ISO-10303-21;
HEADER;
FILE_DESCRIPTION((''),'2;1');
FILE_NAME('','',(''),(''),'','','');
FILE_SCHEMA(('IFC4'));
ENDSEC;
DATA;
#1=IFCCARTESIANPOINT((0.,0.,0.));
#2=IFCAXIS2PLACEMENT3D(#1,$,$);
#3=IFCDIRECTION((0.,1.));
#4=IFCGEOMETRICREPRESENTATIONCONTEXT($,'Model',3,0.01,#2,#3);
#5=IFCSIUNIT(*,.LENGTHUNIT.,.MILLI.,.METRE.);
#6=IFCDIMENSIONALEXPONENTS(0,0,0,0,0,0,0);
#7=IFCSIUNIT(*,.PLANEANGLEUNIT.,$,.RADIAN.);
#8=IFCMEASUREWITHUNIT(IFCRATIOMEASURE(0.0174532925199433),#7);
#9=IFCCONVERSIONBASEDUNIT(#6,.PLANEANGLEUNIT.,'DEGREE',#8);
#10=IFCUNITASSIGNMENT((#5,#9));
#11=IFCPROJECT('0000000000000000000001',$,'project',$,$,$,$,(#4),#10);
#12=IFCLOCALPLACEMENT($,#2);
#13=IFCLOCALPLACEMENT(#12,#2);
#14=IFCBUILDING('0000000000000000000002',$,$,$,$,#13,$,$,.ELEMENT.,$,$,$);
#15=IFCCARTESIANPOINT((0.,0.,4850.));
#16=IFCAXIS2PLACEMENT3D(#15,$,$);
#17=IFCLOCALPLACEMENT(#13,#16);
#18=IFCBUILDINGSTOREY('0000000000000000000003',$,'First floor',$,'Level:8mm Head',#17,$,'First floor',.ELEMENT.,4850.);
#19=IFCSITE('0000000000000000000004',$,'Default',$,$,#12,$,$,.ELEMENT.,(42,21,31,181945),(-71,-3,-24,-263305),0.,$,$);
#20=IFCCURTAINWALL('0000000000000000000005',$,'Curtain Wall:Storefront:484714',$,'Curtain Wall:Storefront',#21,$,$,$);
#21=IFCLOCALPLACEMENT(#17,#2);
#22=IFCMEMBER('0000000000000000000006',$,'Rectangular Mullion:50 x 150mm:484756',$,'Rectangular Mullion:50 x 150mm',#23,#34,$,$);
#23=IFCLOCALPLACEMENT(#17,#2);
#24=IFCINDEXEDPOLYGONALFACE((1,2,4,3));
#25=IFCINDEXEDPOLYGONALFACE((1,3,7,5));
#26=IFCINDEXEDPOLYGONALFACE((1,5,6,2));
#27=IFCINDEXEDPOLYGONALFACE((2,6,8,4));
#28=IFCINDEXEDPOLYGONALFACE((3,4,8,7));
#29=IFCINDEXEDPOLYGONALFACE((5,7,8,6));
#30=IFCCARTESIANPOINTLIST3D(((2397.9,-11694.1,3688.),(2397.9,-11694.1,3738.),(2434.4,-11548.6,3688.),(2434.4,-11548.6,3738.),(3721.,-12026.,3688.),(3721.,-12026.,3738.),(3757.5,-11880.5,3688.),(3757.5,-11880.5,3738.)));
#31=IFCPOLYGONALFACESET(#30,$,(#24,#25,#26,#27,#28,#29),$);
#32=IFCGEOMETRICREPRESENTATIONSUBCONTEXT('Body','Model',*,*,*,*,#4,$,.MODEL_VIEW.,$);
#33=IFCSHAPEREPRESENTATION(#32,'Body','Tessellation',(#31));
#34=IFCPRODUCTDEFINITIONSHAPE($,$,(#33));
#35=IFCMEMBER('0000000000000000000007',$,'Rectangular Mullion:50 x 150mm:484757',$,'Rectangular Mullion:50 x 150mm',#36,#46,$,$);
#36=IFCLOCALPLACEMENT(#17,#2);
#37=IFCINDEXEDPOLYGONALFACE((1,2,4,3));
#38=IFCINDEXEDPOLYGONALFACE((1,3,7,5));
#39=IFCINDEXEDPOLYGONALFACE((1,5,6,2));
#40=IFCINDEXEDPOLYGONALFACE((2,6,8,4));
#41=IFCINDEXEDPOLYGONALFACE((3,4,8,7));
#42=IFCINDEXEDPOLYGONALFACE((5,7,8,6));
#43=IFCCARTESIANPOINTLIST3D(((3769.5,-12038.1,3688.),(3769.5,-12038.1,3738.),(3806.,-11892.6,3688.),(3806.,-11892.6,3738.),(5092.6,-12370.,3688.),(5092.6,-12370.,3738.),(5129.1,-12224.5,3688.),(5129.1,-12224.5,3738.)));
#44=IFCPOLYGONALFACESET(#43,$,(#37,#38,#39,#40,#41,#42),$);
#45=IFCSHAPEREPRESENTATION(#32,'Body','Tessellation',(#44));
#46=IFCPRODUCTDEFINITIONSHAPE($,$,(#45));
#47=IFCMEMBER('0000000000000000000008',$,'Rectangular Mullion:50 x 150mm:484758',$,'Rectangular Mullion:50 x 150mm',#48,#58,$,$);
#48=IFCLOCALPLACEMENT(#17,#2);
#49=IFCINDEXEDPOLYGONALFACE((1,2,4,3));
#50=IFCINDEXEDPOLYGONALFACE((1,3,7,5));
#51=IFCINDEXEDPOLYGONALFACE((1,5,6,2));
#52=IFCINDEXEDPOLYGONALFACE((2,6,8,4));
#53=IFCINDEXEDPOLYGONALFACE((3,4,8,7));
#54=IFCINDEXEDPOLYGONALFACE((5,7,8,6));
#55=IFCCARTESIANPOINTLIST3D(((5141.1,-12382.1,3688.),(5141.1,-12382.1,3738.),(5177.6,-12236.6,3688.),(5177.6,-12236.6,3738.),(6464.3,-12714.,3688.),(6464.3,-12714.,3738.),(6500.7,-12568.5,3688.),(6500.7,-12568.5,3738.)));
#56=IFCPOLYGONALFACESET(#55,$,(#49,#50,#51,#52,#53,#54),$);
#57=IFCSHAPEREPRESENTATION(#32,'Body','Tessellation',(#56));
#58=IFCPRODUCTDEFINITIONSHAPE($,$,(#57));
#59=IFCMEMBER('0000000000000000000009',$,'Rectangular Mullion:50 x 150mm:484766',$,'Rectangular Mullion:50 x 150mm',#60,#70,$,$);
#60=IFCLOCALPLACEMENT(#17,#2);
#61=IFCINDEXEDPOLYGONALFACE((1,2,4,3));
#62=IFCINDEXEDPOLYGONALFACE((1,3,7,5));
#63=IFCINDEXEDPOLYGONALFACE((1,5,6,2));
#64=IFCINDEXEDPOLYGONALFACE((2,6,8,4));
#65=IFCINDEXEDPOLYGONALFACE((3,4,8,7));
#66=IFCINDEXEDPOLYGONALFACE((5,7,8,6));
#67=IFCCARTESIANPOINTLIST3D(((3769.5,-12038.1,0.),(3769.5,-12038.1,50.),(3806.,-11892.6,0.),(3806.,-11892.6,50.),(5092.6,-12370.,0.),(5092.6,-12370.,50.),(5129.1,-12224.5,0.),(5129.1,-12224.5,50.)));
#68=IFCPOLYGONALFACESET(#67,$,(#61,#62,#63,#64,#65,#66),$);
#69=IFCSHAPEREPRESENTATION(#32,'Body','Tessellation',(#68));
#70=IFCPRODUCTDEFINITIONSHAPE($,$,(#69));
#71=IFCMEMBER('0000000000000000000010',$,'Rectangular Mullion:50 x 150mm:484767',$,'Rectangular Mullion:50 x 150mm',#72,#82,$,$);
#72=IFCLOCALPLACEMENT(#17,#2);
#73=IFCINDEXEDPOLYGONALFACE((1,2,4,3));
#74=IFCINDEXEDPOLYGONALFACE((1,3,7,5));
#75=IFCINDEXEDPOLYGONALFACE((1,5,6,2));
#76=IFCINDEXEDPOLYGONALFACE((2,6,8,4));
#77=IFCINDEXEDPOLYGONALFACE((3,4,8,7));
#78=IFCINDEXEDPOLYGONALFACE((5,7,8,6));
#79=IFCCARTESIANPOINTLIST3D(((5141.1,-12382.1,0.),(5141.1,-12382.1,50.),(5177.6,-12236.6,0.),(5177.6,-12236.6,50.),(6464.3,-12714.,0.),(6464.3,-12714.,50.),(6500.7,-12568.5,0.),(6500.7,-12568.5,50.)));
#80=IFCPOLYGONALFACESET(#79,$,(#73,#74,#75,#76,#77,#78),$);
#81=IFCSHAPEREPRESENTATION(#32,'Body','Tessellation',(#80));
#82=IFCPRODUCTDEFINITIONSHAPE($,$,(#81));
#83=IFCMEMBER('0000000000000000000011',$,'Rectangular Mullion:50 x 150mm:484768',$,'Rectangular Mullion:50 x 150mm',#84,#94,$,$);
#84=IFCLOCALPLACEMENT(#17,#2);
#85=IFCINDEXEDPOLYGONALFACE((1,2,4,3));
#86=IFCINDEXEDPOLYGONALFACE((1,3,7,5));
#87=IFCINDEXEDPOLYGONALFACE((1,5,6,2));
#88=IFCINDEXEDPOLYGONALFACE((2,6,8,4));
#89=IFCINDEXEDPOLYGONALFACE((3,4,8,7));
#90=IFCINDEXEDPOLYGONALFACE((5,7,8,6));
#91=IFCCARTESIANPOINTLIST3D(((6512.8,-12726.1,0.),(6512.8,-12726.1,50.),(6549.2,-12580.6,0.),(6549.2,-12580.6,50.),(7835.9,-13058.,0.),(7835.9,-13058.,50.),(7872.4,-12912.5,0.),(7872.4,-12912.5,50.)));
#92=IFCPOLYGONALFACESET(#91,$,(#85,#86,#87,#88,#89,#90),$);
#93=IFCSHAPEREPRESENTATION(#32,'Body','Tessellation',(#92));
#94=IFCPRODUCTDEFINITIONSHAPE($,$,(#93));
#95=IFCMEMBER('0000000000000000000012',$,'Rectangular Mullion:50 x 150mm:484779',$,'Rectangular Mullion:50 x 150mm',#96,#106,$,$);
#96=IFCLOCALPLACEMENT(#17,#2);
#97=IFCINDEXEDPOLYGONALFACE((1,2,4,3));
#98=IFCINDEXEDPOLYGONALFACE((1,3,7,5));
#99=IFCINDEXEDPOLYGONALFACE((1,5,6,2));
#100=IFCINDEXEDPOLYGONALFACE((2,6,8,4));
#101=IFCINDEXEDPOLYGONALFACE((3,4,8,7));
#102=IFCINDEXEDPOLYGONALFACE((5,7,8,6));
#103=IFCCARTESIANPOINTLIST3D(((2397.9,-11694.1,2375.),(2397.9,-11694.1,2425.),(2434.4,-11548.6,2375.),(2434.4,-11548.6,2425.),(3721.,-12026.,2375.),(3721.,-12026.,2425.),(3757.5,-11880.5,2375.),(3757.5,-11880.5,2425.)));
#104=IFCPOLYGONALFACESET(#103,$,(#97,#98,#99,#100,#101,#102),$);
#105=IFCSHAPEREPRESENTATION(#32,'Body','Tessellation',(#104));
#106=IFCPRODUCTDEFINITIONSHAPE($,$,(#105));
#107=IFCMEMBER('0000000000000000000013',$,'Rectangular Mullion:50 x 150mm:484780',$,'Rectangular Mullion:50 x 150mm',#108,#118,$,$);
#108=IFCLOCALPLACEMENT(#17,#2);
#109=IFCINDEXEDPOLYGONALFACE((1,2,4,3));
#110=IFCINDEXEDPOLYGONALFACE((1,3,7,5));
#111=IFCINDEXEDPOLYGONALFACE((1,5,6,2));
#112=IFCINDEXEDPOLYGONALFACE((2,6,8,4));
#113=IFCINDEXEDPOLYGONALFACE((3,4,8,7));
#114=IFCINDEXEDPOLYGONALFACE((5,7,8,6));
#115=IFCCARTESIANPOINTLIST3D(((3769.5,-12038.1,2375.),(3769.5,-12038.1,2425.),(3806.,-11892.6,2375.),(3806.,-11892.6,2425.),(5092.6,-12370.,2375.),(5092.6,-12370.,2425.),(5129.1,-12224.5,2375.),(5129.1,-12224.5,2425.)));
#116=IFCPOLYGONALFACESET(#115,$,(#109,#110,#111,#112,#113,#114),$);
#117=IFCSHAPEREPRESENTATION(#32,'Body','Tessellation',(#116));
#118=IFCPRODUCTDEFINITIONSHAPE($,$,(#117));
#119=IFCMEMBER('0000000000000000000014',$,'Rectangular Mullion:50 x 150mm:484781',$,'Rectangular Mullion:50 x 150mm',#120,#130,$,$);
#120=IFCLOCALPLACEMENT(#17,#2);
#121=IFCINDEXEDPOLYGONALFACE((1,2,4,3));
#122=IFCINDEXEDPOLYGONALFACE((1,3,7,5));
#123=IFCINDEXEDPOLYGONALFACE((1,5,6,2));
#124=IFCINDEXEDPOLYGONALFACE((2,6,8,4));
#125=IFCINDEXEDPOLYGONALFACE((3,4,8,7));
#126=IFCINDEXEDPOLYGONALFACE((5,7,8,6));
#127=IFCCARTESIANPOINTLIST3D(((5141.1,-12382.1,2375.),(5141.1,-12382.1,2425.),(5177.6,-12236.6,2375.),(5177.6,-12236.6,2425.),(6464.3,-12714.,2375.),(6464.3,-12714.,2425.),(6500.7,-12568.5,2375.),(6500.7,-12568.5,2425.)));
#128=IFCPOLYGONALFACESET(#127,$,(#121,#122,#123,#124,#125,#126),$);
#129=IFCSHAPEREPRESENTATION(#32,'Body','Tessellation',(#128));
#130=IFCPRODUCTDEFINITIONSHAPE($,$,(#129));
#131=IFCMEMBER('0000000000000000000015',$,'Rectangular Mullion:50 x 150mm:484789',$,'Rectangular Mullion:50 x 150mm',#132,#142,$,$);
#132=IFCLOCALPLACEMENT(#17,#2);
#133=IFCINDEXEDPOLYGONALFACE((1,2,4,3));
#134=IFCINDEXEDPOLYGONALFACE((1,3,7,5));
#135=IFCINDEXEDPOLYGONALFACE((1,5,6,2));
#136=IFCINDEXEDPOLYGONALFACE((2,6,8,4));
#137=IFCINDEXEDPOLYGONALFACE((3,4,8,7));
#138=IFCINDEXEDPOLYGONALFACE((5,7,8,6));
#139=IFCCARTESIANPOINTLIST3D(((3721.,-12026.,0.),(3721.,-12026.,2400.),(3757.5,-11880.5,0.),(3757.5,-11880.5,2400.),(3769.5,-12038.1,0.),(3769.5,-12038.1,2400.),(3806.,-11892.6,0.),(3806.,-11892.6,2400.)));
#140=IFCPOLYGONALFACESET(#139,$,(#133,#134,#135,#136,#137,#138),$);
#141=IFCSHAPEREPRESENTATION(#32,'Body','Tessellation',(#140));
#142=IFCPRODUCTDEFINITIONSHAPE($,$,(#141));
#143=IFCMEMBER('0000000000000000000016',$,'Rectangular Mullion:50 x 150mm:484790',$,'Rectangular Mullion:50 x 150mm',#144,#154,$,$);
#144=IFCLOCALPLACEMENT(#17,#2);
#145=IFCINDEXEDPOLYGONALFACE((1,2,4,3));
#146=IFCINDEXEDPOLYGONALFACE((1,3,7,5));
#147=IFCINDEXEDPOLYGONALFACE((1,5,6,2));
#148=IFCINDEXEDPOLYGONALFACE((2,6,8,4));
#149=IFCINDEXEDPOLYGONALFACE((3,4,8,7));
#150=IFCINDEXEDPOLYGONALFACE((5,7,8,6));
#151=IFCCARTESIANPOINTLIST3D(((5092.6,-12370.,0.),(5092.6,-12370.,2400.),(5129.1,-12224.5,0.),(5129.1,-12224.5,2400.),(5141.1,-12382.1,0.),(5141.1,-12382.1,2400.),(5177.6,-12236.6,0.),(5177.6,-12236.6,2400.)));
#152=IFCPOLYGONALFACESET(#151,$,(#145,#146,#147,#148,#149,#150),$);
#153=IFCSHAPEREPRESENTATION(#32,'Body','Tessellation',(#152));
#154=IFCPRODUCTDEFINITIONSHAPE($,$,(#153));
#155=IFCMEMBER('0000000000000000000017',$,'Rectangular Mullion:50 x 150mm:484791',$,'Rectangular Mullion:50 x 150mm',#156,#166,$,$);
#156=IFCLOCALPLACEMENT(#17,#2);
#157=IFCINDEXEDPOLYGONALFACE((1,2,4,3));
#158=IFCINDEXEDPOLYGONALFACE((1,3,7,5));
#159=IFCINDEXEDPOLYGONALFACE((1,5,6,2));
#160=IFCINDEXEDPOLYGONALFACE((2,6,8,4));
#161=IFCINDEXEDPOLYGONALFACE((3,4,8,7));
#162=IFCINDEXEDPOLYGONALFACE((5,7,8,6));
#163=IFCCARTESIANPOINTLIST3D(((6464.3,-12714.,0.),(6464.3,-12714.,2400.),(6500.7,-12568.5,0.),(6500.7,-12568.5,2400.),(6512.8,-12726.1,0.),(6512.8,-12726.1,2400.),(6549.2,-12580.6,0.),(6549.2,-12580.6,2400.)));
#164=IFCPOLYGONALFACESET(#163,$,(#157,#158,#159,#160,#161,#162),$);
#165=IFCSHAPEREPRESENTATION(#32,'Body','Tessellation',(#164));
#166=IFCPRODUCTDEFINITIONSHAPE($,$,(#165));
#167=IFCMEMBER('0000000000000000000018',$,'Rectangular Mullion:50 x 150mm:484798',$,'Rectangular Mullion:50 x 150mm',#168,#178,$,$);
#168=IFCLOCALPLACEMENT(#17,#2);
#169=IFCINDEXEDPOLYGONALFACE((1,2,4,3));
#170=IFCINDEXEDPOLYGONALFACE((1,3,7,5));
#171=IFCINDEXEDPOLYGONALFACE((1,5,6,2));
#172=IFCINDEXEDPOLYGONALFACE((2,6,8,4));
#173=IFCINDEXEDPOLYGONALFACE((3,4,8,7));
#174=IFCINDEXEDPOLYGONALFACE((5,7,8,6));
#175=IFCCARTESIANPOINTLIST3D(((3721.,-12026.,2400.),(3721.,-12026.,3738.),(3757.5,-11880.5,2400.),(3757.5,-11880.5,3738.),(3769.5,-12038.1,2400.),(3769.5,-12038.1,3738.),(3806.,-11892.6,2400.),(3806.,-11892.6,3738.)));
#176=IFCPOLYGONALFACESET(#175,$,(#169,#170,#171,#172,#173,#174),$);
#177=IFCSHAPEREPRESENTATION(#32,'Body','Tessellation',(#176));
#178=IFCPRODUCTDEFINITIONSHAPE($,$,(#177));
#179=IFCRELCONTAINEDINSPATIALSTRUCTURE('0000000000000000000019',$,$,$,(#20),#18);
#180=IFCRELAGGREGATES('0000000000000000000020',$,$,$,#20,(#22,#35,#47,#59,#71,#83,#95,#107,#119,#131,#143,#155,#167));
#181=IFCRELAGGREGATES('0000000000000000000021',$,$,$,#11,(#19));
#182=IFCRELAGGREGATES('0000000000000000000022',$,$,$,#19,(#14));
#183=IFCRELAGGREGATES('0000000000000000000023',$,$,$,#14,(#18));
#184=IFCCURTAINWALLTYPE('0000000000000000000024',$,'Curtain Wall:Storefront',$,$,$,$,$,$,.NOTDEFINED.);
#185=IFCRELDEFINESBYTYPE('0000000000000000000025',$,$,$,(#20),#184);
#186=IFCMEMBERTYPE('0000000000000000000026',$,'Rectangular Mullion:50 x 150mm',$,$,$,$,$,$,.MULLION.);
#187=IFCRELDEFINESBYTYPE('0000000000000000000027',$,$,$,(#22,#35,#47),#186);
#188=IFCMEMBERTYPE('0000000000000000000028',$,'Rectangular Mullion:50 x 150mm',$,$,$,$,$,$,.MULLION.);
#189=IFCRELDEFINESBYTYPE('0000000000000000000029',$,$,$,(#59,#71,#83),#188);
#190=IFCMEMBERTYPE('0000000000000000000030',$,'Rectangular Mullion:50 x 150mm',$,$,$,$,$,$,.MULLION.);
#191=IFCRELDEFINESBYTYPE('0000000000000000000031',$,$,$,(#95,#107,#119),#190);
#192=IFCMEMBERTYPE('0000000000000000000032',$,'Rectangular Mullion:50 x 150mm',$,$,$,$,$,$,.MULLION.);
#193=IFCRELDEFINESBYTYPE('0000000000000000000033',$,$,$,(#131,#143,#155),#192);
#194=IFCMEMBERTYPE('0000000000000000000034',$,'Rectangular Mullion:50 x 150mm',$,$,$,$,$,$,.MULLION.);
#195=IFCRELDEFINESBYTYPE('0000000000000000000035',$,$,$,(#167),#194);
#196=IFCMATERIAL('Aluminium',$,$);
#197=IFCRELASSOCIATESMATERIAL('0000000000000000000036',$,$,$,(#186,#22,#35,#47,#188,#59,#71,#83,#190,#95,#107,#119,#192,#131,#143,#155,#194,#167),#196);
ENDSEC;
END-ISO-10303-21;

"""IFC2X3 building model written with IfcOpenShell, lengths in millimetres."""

from ifc_helpers import new_model, entity, si_unit, converted_unit, direction, frame, origin, origin_2d_with_axis, place, context, subcontext, project, spatial, rectangle, extrude, source, transform, mapped, material, type_object, type_shapes, element, aggregate, save


model = new_model("IFC2X3")

# Units and contexts
model_context = context("Model", 3, precision=0.01, world=origin(), true_north=direction((0.0, 1.0)))
body_context = subcontext(model_context, "Body", "Model", "MODEL_VIEW")
ifc_project = project(units=[si_unit("LENGTHUNIT", "METRE", prefix="MILLI"), converted_unit("PLANEANGLEUNIT", "DEGREE", entity("IfcRatioMeasure", 0.0174532925199433), si_unit("PLANEANGLEUNIT", "RADIAN"), dimensions=[0, 0, 0, 0, 0, 0, 0])], contexts=[model_context])

# Site, building, storey
site_placement = place(None, origin())
site = spatial("IfcSite", under=ifc_project, at=site_placement, Name="Default", CompositionType="ELEMENT", RefLatitude=(42, 21, 31, 181945), RefLongitude=(-71, -3, -24, -263305), RefElevation=0.0)
building_placement = place(site_placement, origin())
building = spatial("IfcBuilding", under=site, at=building_placement, CompositionType="ELEMENT")
storey_placement = place(building_placement, frame((0.0, 0.0, 4850.0)))
storey = spatial("IfcBuildingStorey", under=building, at=storey_placement, Name="First floor", ObjectType="Level:8mm Head", LongName="First floor", CompositionType="ELEMENT", Elevation=4850.0)

# Curtain wall, members
curtain_wall_type = type_object("IfcCurtainWallType", Name="Curtain Wall:Storefront", PredefinedType="NOTDEFINED")
curtain_wall_placement = place(storey_placement, frame((0.0, 0.0, -4850.0)))
curtain_wall = element("IfcCurtainWall", 1, at=curtain_wall_placement, inside=storey, type_object=curtain_wall_type, Name="Curtain Wall:Storefront:484714", ObjectType="Curtain Wall:Storefront")
ifc_material_1 = material(Name="Aluminium")
member_type_1 = type_object("IfcMemberType", Name="Rectangular Mullion:50 x 150mm", PredefinedType="MULLION", material=ifc_material_1)
shared_shape_1 = source(origin(), body_context, "Body", "SweptSolid", [
    extrude(rectangle(XDim=150.0, YDim=50.0, at=origin_2d_with_axis()), frame((-25.0, 0.0, -1364.1), z_axis=(0.0, 0.0, 1.0), x_axis=(0.0, -1.0, 0.0)), (0.0, 0.0, 1.0), 1364.1),
])
type_shapes(member_type_1, [shared_shape_1])
member_1_placement = place(storey_placement, frame((3739.3, -11953.2, 3738.0), z_axis=(0.96996, -0.243265, 0.0), x_axis=(0.0, 0.0, 1.0)))
member_1 = element("IfcMember", 2, at=member_1_placement, type_object=member_type_1, material=ifc_material_1, Name="Rectangular Mullion:50 x 150mm:484756", ObjectType="Rectangular Mullion:50 x 150mm", context=body_context, shape_type="MappedRepresentation", body=[
    mapped(shared_shape_1, transform((0.0, 0.0, 0.0), scale=1.0)),
])
member_2_placement = place(storey_placement, frame((5110.9, -12297.2, 3738.0), z_axis=(0.96996, -0.243265, 0.0), x_axis=(0.0, 0.0, 1.0)))
member_2 = element("IfcMember", 3, at=member_2_placement, type_object=member_type_1, material=ifc_material_1, Name="Rectangular Mullion:50 x 150mm:484757", ObjectType="Rectangular Mullion:50 x 150mm", context=body_context, shape_type="MappedRepresentation", body=[
    mapped(shared_shape_1, transform((0.0, 0.0, 0.0), scale=1.0)),
])
member_3_placement = place(storey_placement, frame((6482.5, -12641.2, 3738.0), z_axis=(0.96996, -0.243265, 0.0), x_axis=(0.0, 0.0, 1.0)))
member_3 = element("IfcMember", 4, at=member_3_placement, type_object=member_type_1, material=ifc_material_1, Name="Rectangular Mullion:50 x 150mm:484758", ObjectType="Rectangular Mullion:50 x 150mm", context=body_context, shape_type="MappedRepresentation", body=[
    mapped(shared_shape_1, transform((0.0, 0.0, 0.0), scale=1.0)),
])
member_type_2 = type_object("IfcMemberType", Name="Rectangular Mullion:50 x 150mm", PredefinedType="MULLION", material=ifc_material_1)
shared_shape_2 = source(origin(), body_context, "Body", "SweptSolid", [
    extrude(rectangle(XDim=150.0, YDim=50.0, at=origin_2d_with_axis()), frame((-25.0, 0.0, -1364.1), z_axis=(0.0, 0.0, 1.0), x_axis=(0.0, -1.0, 0.0)), (0.0, 0.0, 1.0), 1364.1),
])
type_shapes(member_type_2, [shared_shape_2])
member_4_placement = place(storey_placement, frame((3787.8, -11965.4, 0.0), z_axis=(-0.96996, 0.243265, 0.0), x_axis=(0.0, 0.0, -1.0)))
member_4 = element("IfcMember", 5, at=member_4_placement, type_object=member_type_2, material=ifc_material_1, Name="Rectangular Mullion:50 x 150mm:484766", ObjectType="Rectangular Mullion:50 x 150mm", context=body_context, shape_type="MappedRepresentation", body=[
    mapped(shared_shape_2, transform((0.0, 0.0, 0.0), scale=1.0)),
])
member_5_placement = place(storey_placement, frame((5159.4, -12309.4, 0.0), z_axis=(-0.96996, 0.243265, 0.0), x_axis=(0.0, 0.0, -1.0)))
member_5 = element("IfcMember", 6, at=member_5_placement, type_object=member_type_2, material=ifc_material_1, Name="Rectangular Mullion:50 x 150mm:484767", ObjectType="Rectangular Mullion:50 x 150mm", context=body_context, shape_type="MappedRepresentation", body=[
    mapped(shared_shape_2, transform((0.0, 0.0, 0.0), scale=1.0)),
])
member_6_placement = place(storey_placement, frame((6531.0, -12653.4, 0.0), z_axis=(-0.96996, 0.243265, 0.0), x_axis=(0.0, 0.0, -1.0)))
member_6 = element("IfcMember", 7, at=member_6_placement, type_object=member_type_2, material=ifc_material_1, Name="Rectangular Mullion:50 x 150mm:484768", ObjectType="Rectangular Mullion:50 x 150mm", context=body_context, shape_type="MappedRepresentation", body=[
    mapped(shared_shape_2, transform((0.0, 0.0, 0.0), scale=1.0)),
])
member_type_3 = type_object("IfcMemberType", Name="Rectangular Mullion:50 x 150mm", PredefinedType="MULLION", material=ifc_material_1)
shared_shape_3 = source(origin(), body_context, "Body", "SweptSolid", [
    extrude(rectangle(XDim=150.0, YDim=50.0, at=origin_2d_with_axis()), frame((0.0, 0.0, -1364.1), z_axis=(0.0, 0.0, 1.0), x_axis=(0.0, -1.0, 0.0)), (0.0, 0.0, 1.0), 1364.1),
])
type_shapes(member_type_3, [shared_shape_3])
member_7_placement = place(storey_placement, frame((3739.3, -11953.2, 2400.0), z_axis=(0.96996, -0.243265, 0.0), x_axis=(0.0, 0.0, 1.0)))
member_7 = element("IfcMember", 8, at=member_7_placement, type_object=member_type_3, material=ifc_material_1, Name="Rectangular Mullion:50 x 150mm:484779", ObjectType="Rectangular Mullion:50 x 150mm", context=body_context, shape_type="MappedRepresentation", body=[
    mapped(shared_shape_3, transform((0.0, 0.0, 0.0), scale=1.0)),
])
member_8_placement = place(storey_placement, frame((5110.9, -12297.2, 2400.0), z_axis=(0.96996, -0.243265, 0.0), x_axis=(0.0, 0.0, 1.0)))
member_8 = element("IfcMember", 9, at=member_8_placement, type_object=member_type_3, material=ifc_material_1, Name="Rectangular Mullion:50 x 150mm:484780", ObjectType="Rectangular Mullion:50 x 150mm", context=body_context, shape_type="MappedRepresentation", body=[
    mapped(shared_shape_3, transform((0.0, 0.0, 0.0), scale=1.0)),
])
member_9_placement = place(storey_placement, frame((6482.5, -12641.2, 2400.0), z_axis=(0.96996, -0.243265, 0.0), x_axis=(0.0, 0.0, 1.0)))
member_9 = element("IfcMember", 10, at=member_9_placement, type_object=member_type_3, material=ifc_material_1, Name="Rectangular Mullion:50 x 150mm:484781", ObjectType="Rectangular Mullion:50 x 150mm", context=body_context, shape_type="MappedRepresentation", body=[
    mapped(shared_shape_3, transform((0.0, 0.0, 0.0), scale=1.0)),
])
member_type_4 = type_object("IfcMemberType", Name="Rectangular Mullion:50 x 150mm", PredefinedType="MULLION", material=ifc_material_1)
shared_shape_4 = source(origin(), body_context, "Body", "SweptSolid", [
    extrude(rectangle(XDim=150.0, YDim=50.0, at=origin_2d_with_axis()), frame((0.0, 0.0, -2400.0), z_axis=(0.0, 0.0, 1.0), x_axis=(0.0, -1.0, 0.0)), (0.0, 0.0, 1.0), 2400.0),
])
type_shapes(member_type_4, [shared_shape_4])
member_10_placement = place(storey_placement, frame((3763.5, -11959.3, 0.0), z_axis=(0.0, 0.0, -1.0), x_axis=(0.96996, -0.243265, 0.0)))
member_10 = element("IfcMember", 11, at=member_10_placement, type_object=member_type_4, material=ifc_material_1, Name="Rectangular Mullion:50 x 150mm:484789", ObjectType="Rectangular Mullion:50 x 150mm", context=body_context, shape_type="MappedRepresentation", body=[
    mapped(shared_shape_4, transform((0.0, 0.0, 0.0), scale=1.0)),
])
member_11_placement = place(storey_placement, frame((5135.1, -12303.3, 0.0), z_axis=(0.0, 0.0, -1.0), x_axis=(0.96996, -0.243265, 0.0)))
member_11 = element("IfcMember", 12, at=member_11_placement, type_object=member_type_4, material=ifc_material_1, Name="Rectangular Mullion:50 x 150mm:484790", ObjectType="Rectangular Mullion:50 x 150mm", context=body_context, shape_type="MappedRepresentation", body=[
    mapped(shared_shape_4, transform((0.0, 0.0, 0.0), scale=1.0)),
])
member_12_placement = place(storey_placement, frame((6506.8, -12647.3, 0.0), z_axis=(0.0, 0.0, -1.0), x_axis=(0.96996, -0.243265, 0.0)))
member_12 = element("IfcMember", 13, at=member_12_placement, type_object=member_type_4, material=ifc_material_1, Name="Rectangular Mullion:50 x 150mm:484791", ObjectType="Rectangular Mullion:50 x 150mm", context=body_context, shape_type="MappedRepresentation", body=[
    mapped(shared_shape_4, transform((0.0, 0.0, 0.0), scale=1.0)),
])
member_type_5 = type_object("IfcMemberType", Name="Rectangular Mullion:50 x 150mm", PredefinedType="MULLION", material=ifc_material_1)
shared_shape_5 = source(origin(), body_context, "Body", "SweptSolid", [
    extrude(rectangle(XDim=150.0, YDim=50.0, at=origin_2d_with_axis()), frame((0.0, 0.0, -1338.0), z_axis=(0.0, 0.0, 1.0), x_axis=(0.0, -1.0, 0.0)), (0.0, 0.0, 1.0), 1338.0),
])
type_shapes(member_type_5, [shared_shape_5])
member_13_placement = place(storey_placement, frame((3763.5, -11959.3, 2400.0), z_axis=(0.0, 0.0, -1.0), x_axis=(0.96996, -0.243265, 0.0)))
member_13 = element("IfcMember", 14, at=member_13_placement, type_object=member_type_5, material=ifc_material_1, Name="Rectangular Mullion:50 x 150mm:484798", ObjectType="Rectangular Mullion:50 x 150mm", context=body_context, shape_type="MappedRepresentation", body=[
    mapped(shared_shape_5, transform((0.0, 0.0, 0.0), scale=1.0)),
])
aggregate(curtain_wall, [member_1, member_2, member_3, member_4, member_5, member_6, member_7, member_8, member_9, member_10, member_11, member_12, member_13])

save(model, "model.ifc")
